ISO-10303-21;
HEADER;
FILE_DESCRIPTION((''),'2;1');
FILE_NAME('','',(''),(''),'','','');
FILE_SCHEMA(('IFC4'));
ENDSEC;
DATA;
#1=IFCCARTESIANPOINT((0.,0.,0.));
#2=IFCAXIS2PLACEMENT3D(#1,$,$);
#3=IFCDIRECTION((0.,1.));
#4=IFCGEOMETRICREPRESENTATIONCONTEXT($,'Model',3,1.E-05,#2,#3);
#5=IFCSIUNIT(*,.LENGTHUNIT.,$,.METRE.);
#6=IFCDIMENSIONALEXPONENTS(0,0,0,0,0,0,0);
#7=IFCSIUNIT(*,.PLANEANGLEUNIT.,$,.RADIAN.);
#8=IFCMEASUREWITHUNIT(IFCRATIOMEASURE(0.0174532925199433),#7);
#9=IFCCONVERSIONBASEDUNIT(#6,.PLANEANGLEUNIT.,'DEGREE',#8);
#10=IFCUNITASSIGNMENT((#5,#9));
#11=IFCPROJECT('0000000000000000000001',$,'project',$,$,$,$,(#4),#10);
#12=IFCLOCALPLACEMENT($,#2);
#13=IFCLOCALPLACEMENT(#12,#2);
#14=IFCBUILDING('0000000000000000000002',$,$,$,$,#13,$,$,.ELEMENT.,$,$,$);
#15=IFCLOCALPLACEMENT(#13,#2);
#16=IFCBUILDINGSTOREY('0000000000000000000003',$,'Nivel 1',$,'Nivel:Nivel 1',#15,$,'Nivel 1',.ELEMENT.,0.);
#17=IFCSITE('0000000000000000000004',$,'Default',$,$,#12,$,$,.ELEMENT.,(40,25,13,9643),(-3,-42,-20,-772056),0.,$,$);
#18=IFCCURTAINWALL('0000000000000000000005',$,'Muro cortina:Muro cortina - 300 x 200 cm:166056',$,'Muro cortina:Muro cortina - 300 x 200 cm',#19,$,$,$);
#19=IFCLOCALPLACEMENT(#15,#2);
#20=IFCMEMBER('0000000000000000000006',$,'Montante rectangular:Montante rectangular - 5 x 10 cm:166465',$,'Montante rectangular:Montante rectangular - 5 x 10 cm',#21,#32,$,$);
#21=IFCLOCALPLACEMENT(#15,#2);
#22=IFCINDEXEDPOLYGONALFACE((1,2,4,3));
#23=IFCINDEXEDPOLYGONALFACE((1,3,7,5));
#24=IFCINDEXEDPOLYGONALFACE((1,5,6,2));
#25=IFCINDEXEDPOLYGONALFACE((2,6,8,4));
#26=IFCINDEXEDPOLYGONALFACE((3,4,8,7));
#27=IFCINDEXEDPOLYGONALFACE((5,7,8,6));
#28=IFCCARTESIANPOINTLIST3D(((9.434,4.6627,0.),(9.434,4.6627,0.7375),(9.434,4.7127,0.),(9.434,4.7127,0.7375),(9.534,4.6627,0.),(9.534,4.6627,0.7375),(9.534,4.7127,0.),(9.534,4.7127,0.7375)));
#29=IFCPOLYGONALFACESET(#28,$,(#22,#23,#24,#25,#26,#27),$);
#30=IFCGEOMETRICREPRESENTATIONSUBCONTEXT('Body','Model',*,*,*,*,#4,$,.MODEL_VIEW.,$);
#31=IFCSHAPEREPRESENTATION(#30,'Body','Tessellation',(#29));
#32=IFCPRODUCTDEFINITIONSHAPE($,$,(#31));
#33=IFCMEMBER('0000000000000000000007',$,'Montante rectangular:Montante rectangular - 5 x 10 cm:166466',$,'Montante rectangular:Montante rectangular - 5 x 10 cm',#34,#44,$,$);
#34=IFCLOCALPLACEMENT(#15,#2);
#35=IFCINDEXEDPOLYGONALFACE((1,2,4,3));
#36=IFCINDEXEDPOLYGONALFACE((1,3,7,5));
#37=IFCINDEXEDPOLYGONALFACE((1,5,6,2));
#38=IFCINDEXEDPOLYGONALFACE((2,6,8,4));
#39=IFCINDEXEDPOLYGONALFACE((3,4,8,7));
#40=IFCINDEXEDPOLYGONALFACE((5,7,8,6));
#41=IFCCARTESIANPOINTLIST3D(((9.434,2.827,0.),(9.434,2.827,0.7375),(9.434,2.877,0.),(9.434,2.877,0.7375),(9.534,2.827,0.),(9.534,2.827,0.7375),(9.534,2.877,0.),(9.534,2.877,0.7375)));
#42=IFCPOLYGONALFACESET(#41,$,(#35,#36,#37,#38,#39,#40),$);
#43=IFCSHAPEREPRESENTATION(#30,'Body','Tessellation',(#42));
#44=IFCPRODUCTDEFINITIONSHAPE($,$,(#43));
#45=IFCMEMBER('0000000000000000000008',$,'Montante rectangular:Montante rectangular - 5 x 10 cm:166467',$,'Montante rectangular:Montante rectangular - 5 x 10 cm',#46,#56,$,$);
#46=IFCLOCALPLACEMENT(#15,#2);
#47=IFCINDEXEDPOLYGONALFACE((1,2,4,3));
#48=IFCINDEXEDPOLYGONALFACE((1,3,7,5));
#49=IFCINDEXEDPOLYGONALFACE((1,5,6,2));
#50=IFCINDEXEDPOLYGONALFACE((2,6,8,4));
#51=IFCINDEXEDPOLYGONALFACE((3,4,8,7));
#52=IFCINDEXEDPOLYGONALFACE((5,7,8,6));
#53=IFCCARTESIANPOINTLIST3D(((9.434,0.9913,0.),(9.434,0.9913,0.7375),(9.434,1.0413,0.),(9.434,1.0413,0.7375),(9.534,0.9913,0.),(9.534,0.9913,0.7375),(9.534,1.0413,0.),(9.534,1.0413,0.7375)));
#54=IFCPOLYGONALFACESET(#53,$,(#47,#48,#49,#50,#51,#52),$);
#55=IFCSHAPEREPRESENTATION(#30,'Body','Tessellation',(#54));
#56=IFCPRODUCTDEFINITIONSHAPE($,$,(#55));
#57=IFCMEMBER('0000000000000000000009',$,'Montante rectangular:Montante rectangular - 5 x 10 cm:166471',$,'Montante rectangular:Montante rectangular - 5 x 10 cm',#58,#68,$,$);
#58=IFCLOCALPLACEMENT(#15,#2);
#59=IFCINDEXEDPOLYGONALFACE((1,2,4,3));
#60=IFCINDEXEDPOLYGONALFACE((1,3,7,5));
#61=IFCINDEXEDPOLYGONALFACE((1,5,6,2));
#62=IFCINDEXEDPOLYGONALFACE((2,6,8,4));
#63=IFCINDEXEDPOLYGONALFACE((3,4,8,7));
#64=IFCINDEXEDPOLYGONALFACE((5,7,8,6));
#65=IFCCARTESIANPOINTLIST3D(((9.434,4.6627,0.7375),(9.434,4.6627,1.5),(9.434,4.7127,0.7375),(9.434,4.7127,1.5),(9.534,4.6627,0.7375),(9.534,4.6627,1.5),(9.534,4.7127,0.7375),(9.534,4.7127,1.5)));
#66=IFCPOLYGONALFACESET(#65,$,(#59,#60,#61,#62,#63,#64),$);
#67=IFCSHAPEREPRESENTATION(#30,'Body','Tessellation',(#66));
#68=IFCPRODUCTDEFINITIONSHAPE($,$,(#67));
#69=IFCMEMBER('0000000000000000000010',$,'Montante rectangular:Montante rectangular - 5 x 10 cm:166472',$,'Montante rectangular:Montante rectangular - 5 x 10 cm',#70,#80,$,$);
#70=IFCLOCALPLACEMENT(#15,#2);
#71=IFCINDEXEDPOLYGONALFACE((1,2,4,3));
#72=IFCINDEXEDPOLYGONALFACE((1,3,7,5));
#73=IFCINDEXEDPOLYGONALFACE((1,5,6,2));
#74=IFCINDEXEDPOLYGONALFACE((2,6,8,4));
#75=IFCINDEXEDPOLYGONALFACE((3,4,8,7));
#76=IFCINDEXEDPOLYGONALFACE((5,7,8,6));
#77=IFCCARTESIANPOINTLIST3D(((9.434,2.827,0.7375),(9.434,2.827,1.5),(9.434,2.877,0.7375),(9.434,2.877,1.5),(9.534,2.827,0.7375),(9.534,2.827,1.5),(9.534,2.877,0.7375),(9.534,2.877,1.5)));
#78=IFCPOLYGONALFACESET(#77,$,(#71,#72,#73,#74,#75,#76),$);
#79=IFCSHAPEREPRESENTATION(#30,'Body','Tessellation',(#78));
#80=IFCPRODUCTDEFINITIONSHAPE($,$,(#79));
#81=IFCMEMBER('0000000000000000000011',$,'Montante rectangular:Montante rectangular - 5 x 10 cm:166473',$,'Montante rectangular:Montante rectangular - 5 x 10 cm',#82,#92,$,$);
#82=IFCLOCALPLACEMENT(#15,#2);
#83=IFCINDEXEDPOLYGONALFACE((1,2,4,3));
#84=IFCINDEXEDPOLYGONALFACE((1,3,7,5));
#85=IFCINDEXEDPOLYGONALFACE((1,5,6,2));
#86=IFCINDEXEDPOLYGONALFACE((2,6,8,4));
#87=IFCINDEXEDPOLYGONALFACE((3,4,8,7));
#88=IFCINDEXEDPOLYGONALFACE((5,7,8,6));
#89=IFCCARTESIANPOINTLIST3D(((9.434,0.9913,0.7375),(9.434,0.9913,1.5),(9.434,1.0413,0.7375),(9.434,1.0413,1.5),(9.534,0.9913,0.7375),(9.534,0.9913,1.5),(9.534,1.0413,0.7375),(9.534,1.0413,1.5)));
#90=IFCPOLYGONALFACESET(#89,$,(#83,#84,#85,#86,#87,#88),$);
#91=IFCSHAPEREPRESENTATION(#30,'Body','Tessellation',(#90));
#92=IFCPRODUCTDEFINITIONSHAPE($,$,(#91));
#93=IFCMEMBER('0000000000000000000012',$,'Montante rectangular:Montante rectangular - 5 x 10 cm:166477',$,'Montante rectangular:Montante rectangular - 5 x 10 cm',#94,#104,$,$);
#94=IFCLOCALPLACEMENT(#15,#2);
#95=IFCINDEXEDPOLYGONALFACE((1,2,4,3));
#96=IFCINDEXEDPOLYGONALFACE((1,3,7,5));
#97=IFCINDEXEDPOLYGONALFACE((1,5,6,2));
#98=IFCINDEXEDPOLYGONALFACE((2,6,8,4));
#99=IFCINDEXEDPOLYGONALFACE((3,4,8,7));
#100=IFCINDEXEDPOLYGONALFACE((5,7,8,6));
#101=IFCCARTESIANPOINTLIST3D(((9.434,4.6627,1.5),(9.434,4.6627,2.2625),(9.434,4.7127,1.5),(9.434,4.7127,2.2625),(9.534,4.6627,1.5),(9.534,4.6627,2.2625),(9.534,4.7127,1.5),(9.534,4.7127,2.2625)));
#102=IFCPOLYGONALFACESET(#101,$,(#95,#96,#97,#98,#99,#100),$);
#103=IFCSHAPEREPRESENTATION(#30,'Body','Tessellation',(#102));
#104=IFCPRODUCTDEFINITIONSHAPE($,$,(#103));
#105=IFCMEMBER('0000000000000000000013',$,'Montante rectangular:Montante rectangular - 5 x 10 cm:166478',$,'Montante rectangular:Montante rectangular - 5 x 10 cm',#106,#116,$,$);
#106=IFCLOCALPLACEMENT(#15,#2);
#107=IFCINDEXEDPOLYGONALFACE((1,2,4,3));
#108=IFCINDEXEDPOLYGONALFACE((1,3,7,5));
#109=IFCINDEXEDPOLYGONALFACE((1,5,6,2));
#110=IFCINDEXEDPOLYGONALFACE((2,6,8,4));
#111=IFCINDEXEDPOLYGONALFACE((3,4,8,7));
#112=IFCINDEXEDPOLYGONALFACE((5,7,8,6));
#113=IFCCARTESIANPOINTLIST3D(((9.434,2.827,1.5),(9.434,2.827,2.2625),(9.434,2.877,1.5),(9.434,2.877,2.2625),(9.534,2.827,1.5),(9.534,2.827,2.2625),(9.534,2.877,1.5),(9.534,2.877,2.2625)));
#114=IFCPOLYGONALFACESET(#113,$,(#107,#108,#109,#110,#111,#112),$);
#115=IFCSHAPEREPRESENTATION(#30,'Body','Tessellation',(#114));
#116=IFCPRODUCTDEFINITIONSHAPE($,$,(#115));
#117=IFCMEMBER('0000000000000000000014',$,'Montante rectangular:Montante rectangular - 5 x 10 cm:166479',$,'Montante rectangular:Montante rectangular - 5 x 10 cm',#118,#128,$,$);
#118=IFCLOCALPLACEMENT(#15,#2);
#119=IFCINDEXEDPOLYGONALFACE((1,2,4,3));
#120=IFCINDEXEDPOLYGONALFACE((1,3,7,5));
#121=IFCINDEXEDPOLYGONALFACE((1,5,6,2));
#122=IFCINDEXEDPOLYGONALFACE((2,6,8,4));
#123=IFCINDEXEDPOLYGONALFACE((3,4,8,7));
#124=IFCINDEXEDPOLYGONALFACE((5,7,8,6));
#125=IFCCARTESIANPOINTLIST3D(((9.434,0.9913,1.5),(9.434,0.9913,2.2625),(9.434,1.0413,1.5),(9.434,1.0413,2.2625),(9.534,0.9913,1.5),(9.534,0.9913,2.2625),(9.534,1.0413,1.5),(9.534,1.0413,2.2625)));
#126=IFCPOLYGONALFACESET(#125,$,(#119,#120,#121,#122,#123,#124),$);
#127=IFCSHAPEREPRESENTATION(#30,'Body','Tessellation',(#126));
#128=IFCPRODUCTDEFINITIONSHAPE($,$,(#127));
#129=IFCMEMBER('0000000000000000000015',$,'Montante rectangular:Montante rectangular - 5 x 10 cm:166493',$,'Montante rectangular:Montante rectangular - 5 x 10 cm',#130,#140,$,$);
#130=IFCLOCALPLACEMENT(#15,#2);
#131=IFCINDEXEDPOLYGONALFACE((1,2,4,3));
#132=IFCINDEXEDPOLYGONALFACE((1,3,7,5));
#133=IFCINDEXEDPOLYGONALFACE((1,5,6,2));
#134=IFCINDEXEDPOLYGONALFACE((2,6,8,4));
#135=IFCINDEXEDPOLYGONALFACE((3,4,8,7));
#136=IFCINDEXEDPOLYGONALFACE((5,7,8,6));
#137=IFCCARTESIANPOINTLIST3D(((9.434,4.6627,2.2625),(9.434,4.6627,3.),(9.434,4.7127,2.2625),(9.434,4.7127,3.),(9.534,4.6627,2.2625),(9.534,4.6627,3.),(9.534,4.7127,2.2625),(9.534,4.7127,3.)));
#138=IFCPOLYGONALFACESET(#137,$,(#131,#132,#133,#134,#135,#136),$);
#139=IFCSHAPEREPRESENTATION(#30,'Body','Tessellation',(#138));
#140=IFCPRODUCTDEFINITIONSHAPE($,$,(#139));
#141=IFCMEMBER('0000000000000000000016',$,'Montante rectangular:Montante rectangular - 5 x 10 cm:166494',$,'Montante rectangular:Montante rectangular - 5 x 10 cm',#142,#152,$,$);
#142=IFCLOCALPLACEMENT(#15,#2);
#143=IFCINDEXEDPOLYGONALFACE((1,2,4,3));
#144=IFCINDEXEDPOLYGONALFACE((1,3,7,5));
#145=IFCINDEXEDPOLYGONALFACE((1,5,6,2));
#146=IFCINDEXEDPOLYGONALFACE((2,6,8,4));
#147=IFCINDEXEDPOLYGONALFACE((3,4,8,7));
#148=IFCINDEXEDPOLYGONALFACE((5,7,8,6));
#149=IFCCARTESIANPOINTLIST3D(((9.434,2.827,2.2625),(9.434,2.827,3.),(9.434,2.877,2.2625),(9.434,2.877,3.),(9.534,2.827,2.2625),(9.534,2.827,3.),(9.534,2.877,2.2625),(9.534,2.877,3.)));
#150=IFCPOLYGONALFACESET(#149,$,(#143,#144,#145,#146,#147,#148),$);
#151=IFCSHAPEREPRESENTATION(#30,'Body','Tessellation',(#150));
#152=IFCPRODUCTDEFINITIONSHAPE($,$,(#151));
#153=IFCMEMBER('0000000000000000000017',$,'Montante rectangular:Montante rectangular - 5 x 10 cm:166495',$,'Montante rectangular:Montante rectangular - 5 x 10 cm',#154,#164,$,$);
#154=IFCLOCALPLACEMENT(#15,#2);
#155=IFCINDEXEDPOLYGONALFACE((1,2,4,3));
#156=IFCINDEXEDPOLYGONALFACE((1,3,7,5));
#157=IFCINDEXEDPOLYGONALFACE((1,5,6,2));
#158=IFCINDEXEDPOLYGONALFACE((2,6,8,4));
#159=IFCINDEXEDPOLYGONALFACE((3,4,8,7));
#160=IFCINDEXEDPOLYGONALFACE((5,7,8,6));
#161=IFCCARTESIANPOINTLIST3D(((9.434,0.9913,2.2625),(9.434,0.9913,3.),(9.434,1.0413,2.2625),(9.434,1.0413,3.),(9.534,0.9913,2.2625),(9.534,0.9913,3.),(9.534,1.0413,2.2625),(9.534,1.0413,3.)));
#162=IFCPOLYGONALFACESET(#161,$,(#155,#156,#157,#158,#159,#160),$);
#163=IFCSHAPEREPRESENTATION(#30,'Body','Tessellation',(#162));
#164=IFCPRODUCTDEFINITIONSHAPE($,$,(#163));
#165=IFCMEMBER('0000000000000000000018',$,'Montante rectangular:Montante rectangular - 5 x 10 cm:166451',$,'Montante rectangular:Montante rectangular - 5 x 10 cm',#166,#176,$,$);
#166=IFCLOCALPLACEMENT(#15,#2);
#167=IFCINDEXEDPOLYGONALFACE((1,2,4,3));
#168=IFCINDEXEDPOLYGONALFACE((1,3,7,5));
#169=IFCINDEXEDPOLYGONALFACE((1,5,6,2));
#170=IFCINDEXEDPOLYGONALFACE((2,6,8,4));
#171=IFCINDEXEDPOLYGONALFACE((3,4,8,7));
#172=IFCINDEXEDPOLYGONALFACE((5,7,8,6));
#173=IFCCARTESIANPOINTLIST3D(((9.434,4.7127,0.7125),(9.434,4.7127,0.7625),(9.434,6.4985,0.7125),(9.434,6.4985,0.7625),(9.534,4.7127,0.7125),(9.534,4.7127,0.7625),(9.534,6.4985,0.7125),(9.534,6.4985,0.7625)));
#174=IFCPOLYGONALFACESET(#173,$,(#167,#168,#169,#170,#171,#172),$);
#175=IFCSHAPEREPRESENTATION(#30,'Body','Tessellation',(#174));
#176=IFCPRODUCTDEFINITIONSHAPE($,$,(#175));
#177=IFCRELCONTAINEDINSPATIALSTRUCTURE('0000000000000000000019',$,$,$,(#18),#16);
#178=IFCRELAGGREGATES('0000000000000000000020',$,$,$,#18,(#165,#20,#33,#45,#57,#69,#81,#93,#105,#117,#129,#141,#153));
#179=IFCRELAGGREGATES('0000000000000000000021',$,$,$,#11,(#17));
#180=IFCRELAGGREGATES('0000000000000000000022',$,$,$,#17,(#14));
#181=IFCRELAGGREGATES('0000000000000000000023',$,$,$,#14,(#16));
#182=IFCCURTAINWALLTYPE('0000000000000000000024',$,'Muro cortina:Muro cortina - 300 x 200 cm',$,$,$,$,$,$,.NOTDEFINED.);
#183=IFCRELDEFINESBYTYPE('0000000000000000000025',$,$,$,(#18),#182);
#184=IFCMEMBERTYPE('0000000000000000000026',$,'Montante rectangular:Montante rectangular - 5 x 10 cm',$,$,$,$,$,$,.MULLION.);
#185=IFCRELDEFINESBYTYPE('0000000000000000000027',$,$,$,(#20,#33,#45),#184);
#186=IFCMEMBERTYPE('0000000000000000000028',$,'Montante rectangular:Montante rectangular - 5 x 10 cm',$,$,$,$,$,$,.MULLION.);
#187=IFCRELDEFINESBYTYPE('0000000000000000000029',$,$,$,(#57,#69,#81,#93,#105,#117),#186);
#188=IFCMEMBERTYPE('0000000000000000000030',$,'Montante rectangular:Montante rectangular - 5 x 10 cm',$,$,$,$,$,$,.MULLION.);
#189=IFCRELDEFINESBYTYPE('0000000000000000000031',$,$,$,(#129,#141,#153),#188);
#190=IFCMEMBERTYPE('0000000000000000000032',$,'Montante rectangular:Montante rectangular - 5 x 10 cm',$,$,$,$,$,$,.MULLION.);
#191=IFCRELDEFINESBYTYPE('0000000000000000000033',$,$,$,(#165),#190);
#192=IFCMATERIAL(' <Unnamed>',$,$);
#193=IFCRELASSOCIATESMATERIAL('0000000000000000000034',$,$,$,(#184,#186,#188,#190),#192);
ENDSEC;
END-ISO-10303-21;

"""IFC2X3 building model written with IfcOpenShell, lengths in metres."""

from ifc_helpers import new_model, entity, si_unit, converted_unit, direction, frame, origin, origin_2d_with_axis, place, context, subcontext, project, spatial, rectangle, extrude, source, transform, mapped, material, type_object, type_shapes, element, aggregate, save


model = new_model("IFC2X3")

# Units and contexts
model_context = context("Model", 3, precision=1e-05, world=origin(), true_north=direction((0.0, 1.0)))
body_context = subcontext(model_context, "Body", "Model", "MODEL_VIEW")
ifc_project = project(units=[si_unit("LENGTHUNIT", "METRE"), converted_unit("PLANEANGLEUNIT", "DEGREE", entity("IfcRatioMeasure", 0.0174532925199433), si_unit("PLANEANGLEUNIT", "RADIAN"), dimensions=[0, 0, 0, 0, 0, 0, 0])], contexts=[model_context])

# Site, building, storey
site_placement = place(None, origin())
site = spatial("IfcSite", under=ifc_project, at=site_placement, Name="Default", CompositionType="ELEMENT", RefLatitude=(40, 25, 13, 9643), RefLongitude=(-3, -42, -20, -772056), RefElevation=0.0)
building_placement = place(site_placement, origin())
building = spatial("IfcBuilding", under=site, at=building_placement, CompositionType="ELEMENT")
storey_placement = place(building_placement, origin())
storey = spatial("IfcBuildingStorey", under=building, at=storey_placement, Name="Nivel 1", ObjectType="Nivel:Nivel 1", LongName="Nivel 1", CompositionType="ELEMENT", Elevation=0.0)

# Curtain wall, members
curtain_wall_type = type_object("IfcCurtainWallType", Name="Muro cortina:Muro cortina - 300 x 200 cm", PredefinedType="NOTDEFINED")
curtain_wall_placement = place(storey_placement, origin())
curtain_wall = element("IfcCurtainWall", 1, at=curtain_wall_placement, inside=storey, type_object=curtain_wall_type, Name="Muro cortina:Muro cortina - 300 x 200 cm:166056", ObjectType="Muro cortina:Muro cortina - 300 x 200 cm")
ifc_material_1 = material(Name=" <Unnamed>")
member_type_1 = type_object("IfcMemberType", Name="Montante rectangular:Montante rectangular - 5 x 10 cm", PredefinedType="MULLION", material=ifc_material_1)
shared_shape_1 = source(origin(), body_context, "Body", "SweptSolid", [
    extrude(rectangle(XDim=0.1, YDim=0.05, at=origin_2d_with_axis()), frame((0.0, 0.0, -0.7375), z_axis=(0.0, 0.0, 1.0), x_axis=(0.0, -1.0, 0.0)), (0.0, 0.0, 1.0), 0.7375),
])
type_shapes(member_type_1, [shared_shape_1])
member_1_placement = place(storey_placement, frame((9.484, 4.6877, 0.0), z_axis=(0.0, 0.0, -1.0), x_axis=(0.0, -1.0, 0.0)))
member_1 = element("IfcMember", 2, at=member_1_placement, type_object=member_type_1, Name="Montante rectangular:Montante rectangular - 5 x 10 cm:166465", ObjectType="Montante rectangular:Montante rectangular - 5 x 10 cm", context=body_context, shape_type="MappedRepresentation", body=[
    mapped(shared_shape_1, transform((0.0, 0.0, 0.0), scale=1.0)),
])
member_2_placement = place(storey_placement, frame((9.484, 2.852, 0.0), z_axis=(0.0, 0.0, -1.0), x_axis=(0.0, -1.0, 0.0)))
member_2 = element("IfcMember", 3, at=member_2_placement, type_object=member_type_1, Name="Montante rectangular:Montante rectangular - 5 x 10 cm:166466", ObjectType="Montante rectangular:Montante rectangular - 5 x 10 cm", context=body_context, shape_type="MappedRepresentation", body=[
    mapped(shared_shape_1, transform((0.0, 0.0, 0.0), scale=1.0)),
])
member_3_placement = place(storey_placement, frame((9.484, 1.0163, 0.0), z_axis=(0.0, 0.0, -1.0), x_axis=(0.0, -1.0, 0.0)))
member_3 = element("IfcMember", 4, at=member_3_placement, type_object=member_type_1, Name="Montante rectangular:Montante rectangular - 5 x 10 cm:166467", ObjectType="Montante rectangular:Montante rectangular - 5 x 10 cm", context=body_context, shape_type="MappedRepresentation", body=[
    mapped(shared_shape_1, transform((0.0, 0.0, 0.0), scale=1.0)),
])
member_type_2 = type_object("IfcMemberType", Name="Montante rectangular:Montante rectangular - 5 x 10 cm", PredefinedType="MULLION", material=ifc_material_1)
shared_shape_2 = source(origin(), body_context, "Body", "SweptSolid", [
    extrude(rectangle(XDim=0.1, YDim=0.05, at=origin_2d_with_axis()), frame((0.0, 0.0, -0.7625), z_axis=(0.0, 0.0, 1.0), x_axis=(0.0, -1.0, 0.0)), (0.0, 0.0, 1.0), 0.7625),
])
type_shapes(member_type_2, [shared_shape_2])
member_4_placement = place(storey_placement, frame((9.484, 4.6877, 0.7375), z_axis=(0.0, 0.0, -1.0), x_axis=(0.0, -1.0, 0.0)))
member_4 = element("IfcMember", 5, at=member_4_placement, type_object=member_type_2, Name="Montante rectangular:Montante rectangular - 5 x 10 cm:166471", ObjectType="Montante rectangular:Montante rectangular - 5 x 10 cm", context=body_context, shape_type="MappedRepresentation", body=[
    mapped(shared_shape_2, transform((0.0, 0.0, 0.0), scale=1.0)),
])
member_5_placement = place(storey_placement, frame((9.484, 2.852, 0.7375), z_axis=(0.0, 0.0, -1.0), x_axis=(0.0, -1.0, 0.0)))
member_5 = element("IfcMember", 6, at=member_5_placement, type_object=member_type_2, Name="Montante rectangular:Montante rectangular - 5 x 10 cm:166472", ObjectType="Montante rectangular:Montante rectangular - 5 x 10 cm", context=body_context, shape_type="MappedRepresentation", body=[
    mapped(shared_shape_2, transform((0.0, 0.0, 0.0), scale=1.0)),
])
member_6_placement = place(storey_placement, frame((9.484, 1.0163, 0.7375), z_axis=(0.0, 0.0, -1.0), x_axis=(0.0, -1.0, 0.0)))
member_6 = element("IfcMember", 7, at=member_6_placement, type_object=member_type_2, Name="Montante rectangular:Montante rectangular - 5 x 10 cm:166473", ObjectType="Montante rectangular:Montante rectangular - 5 x 10 cm", context=body_context, shape_type="MappedRepresentation", body=[
    mapped(shared_shape_2, transform((0.0, 0.0, 0.0), scale=1.0)),
])
member_7_placement = place(storey_placement, frame((9.484, 4.6877, 1.5), z_axis=(0.0, 0.0, -1.0), x_axis=(0.0, -1.0, 0.0)))
member_7 = element("IfcMember", 8, at=member_7_placement, type_object=member_type_2, Name="Montante rectangular:Montante rectangular - 5 x 10 cm:166477", ObjectType="Montante rectangular:Montante rectangular - 5 x 10 cm", context=body_context, shape_type="MappedRepresentation", body=[
    mapped(shared_shape_2, transform((0.0, 0.0, 0.0), scale=1.0)),
])
member_8_placement = place(storey_placement, frame((9.484, 2.852, 1.5), z_axis=(0.0, 0.0, -1.0), x_axis=(0.0, -1.0, 0.0)))
member_8 = element("IfcMember", 9, at=member_8_placement, type_object=member_type_2, Name="Montante rectangular:Montante rectangular - 5 x 10 cm:166478", ObjectType="Montante rectangular:Montante rectangular - 5 x 10 cm", context=body_context, shape_type="MappedRepresentation", body=[
    mapped(shared_shape_2, transform((0.0, 0.0, 0.0), scale=1.0)),
])
member_9_placement = place(storey_placement, frame((9.484, 1.0163, 1.5), z_axis=(0.0, 0.0, -1.0), x_axis=(0.0, -1.0, 0.0)))
member_9 = element("IfcMember", 10, at=member_9_placement, type_object=member_type_2, Name="Montante rectangular:Montante rectangular - 5 x 10 cm:166479", ObjectType="Montante rectangular:Montante rectangular - 5 x 10 cm", context=body_context, shape_type="MappedRepresentation", body=[
    mapped(shared_shape_2, transform((0.0, 0.0, 0.0), scale=1.0)),
])
member_type_3 = type_object("IfcMemberType", Name="Montante rectangular:Montante rectangular - 5 x 10 cm", PredefinedType="MULLION", material=ifc_material_1)
shared_shape_3 = source(origin(), body_context, "Body", "SweptSolid", [
    extrude(rectangle(XDim=0.1, YDim=0.05, at=origin_2d_with_axis()), frame((0.0, 0.0, -0.7375), z_axis=(0.0, 0.0, 1.0), x_axis=(0.0, -1.0, 0.0)), (0.0, 0.0, 1.0), 0.7375),
])
type_shapes(member_type_3, [shared_shape_3])
member_10_placement = place(storey_placement, frame((9.484, 4.6877, 2.2625), z_axis=(0.0, 0.0, -1.0), x_axis=(0.0, -1.0, 0.0)))
member_10 = element("IfcMember", 11, at=member_10_placement, type_object=member_type_3, Name="Montante rectangular:Montante rectangular - 5 x 10 cm:166493", ObjectType="Montante rectangular:Montante rectangular - 5 x 10 cm", context=body_context, shape_type="MappedRepresentation", body=[
    mapped(shared_shape_3, transform((0.0, 0.0, 0.0), scale=1.0)),
])
member_11_placement = place(storey_placement, frame((9.484, 2.852, 2.2625), z_axis=(0.0, 0.0, -1.0), x_axis=(0.0, -1.0, 0.0)))
member_11 = element("IfcMember", 12, at=member_11_placement, type_object=member_type_3, Name="Montante rectangular:Montante rectangular - 5 x 10 cm:166494", ObjectType="Montante rectangular:Montante rectangular - 5 x 10 cm", context=body_context, shape_type="MappedRepresentation", body=[
    mapped(shared_shape_3, transform((0.0, 0.0, 0.0), scale=1.0)),
])
member_12_placement = place(storey_placement, frame((9.484, 1.0163, 2.2625), z_axis=(0.0, 0.0, -1.0), x_axis=(0.0, -1.0, 0.0)))
member_12 = element("IfcMember", 13, at=member_12_placement, type_object=member_type_3, Name="Montante rectangular:Montante rectangular - 5 x 10 cm:166495", ObjectType="Montante rectangular:Montante rectangular - 5 x 10 cm", context=body_context, shape_type="MappedRepresentation", body=[
    mapped(shared_shape_3, transform((0.0, 0.0, 0.0), scale=1.0)),
])
member_type_4 = type_object("IfcMemberType", Name="Montante rectangular:Montante rectangular - 5 x 10 cm", PredefinedType="MULLION", material=ifc_material_1)
shared_shape_4 = source(origin(), body_context, "Body", "SweptSolid", [
    extrude(rectangle(XDim=0.1, YDim=0.05, at=origin_2d_with_axis()), frame((0.0, 0.0, -1.7857), z_axis=(0.0, 0.0, 1.0), x_axis=(0.0, -1.0, 0.0)), (0.0, 0.0, 1.0), 1.7857),
])
type_shapes(member_type_4, [shared_shape_4])
member_13_placement = place(storey_placement, frame((9.484, 4.7127, 0.7375), z_axis=(0.0, -1.0, 0.0), x_axis=(0.0, 0.0, 1.0)))
member_13 = element("IfcMember", 14, at=member_13_placement, type_object=member_type_4, Name="Montante rectangular:Montante rectangular - 5 x 10 cm:166451", ObjectType="Montante rectangular:Montante rectangular - 5 x 10 cm", context=body_context, shape_type="MappedRepresentation", body=[
    mapped(shared_shape_4, transform((0.0, 0.0, 0.0), scale=1.0)),
])
aggregate(curtain_wall, [member_13, member_1, member_2, member_3, member_4, member_5, member_6, member_7, member_8, member_9, member_10, member_11, member_12])

save(model, "model.ifc")
